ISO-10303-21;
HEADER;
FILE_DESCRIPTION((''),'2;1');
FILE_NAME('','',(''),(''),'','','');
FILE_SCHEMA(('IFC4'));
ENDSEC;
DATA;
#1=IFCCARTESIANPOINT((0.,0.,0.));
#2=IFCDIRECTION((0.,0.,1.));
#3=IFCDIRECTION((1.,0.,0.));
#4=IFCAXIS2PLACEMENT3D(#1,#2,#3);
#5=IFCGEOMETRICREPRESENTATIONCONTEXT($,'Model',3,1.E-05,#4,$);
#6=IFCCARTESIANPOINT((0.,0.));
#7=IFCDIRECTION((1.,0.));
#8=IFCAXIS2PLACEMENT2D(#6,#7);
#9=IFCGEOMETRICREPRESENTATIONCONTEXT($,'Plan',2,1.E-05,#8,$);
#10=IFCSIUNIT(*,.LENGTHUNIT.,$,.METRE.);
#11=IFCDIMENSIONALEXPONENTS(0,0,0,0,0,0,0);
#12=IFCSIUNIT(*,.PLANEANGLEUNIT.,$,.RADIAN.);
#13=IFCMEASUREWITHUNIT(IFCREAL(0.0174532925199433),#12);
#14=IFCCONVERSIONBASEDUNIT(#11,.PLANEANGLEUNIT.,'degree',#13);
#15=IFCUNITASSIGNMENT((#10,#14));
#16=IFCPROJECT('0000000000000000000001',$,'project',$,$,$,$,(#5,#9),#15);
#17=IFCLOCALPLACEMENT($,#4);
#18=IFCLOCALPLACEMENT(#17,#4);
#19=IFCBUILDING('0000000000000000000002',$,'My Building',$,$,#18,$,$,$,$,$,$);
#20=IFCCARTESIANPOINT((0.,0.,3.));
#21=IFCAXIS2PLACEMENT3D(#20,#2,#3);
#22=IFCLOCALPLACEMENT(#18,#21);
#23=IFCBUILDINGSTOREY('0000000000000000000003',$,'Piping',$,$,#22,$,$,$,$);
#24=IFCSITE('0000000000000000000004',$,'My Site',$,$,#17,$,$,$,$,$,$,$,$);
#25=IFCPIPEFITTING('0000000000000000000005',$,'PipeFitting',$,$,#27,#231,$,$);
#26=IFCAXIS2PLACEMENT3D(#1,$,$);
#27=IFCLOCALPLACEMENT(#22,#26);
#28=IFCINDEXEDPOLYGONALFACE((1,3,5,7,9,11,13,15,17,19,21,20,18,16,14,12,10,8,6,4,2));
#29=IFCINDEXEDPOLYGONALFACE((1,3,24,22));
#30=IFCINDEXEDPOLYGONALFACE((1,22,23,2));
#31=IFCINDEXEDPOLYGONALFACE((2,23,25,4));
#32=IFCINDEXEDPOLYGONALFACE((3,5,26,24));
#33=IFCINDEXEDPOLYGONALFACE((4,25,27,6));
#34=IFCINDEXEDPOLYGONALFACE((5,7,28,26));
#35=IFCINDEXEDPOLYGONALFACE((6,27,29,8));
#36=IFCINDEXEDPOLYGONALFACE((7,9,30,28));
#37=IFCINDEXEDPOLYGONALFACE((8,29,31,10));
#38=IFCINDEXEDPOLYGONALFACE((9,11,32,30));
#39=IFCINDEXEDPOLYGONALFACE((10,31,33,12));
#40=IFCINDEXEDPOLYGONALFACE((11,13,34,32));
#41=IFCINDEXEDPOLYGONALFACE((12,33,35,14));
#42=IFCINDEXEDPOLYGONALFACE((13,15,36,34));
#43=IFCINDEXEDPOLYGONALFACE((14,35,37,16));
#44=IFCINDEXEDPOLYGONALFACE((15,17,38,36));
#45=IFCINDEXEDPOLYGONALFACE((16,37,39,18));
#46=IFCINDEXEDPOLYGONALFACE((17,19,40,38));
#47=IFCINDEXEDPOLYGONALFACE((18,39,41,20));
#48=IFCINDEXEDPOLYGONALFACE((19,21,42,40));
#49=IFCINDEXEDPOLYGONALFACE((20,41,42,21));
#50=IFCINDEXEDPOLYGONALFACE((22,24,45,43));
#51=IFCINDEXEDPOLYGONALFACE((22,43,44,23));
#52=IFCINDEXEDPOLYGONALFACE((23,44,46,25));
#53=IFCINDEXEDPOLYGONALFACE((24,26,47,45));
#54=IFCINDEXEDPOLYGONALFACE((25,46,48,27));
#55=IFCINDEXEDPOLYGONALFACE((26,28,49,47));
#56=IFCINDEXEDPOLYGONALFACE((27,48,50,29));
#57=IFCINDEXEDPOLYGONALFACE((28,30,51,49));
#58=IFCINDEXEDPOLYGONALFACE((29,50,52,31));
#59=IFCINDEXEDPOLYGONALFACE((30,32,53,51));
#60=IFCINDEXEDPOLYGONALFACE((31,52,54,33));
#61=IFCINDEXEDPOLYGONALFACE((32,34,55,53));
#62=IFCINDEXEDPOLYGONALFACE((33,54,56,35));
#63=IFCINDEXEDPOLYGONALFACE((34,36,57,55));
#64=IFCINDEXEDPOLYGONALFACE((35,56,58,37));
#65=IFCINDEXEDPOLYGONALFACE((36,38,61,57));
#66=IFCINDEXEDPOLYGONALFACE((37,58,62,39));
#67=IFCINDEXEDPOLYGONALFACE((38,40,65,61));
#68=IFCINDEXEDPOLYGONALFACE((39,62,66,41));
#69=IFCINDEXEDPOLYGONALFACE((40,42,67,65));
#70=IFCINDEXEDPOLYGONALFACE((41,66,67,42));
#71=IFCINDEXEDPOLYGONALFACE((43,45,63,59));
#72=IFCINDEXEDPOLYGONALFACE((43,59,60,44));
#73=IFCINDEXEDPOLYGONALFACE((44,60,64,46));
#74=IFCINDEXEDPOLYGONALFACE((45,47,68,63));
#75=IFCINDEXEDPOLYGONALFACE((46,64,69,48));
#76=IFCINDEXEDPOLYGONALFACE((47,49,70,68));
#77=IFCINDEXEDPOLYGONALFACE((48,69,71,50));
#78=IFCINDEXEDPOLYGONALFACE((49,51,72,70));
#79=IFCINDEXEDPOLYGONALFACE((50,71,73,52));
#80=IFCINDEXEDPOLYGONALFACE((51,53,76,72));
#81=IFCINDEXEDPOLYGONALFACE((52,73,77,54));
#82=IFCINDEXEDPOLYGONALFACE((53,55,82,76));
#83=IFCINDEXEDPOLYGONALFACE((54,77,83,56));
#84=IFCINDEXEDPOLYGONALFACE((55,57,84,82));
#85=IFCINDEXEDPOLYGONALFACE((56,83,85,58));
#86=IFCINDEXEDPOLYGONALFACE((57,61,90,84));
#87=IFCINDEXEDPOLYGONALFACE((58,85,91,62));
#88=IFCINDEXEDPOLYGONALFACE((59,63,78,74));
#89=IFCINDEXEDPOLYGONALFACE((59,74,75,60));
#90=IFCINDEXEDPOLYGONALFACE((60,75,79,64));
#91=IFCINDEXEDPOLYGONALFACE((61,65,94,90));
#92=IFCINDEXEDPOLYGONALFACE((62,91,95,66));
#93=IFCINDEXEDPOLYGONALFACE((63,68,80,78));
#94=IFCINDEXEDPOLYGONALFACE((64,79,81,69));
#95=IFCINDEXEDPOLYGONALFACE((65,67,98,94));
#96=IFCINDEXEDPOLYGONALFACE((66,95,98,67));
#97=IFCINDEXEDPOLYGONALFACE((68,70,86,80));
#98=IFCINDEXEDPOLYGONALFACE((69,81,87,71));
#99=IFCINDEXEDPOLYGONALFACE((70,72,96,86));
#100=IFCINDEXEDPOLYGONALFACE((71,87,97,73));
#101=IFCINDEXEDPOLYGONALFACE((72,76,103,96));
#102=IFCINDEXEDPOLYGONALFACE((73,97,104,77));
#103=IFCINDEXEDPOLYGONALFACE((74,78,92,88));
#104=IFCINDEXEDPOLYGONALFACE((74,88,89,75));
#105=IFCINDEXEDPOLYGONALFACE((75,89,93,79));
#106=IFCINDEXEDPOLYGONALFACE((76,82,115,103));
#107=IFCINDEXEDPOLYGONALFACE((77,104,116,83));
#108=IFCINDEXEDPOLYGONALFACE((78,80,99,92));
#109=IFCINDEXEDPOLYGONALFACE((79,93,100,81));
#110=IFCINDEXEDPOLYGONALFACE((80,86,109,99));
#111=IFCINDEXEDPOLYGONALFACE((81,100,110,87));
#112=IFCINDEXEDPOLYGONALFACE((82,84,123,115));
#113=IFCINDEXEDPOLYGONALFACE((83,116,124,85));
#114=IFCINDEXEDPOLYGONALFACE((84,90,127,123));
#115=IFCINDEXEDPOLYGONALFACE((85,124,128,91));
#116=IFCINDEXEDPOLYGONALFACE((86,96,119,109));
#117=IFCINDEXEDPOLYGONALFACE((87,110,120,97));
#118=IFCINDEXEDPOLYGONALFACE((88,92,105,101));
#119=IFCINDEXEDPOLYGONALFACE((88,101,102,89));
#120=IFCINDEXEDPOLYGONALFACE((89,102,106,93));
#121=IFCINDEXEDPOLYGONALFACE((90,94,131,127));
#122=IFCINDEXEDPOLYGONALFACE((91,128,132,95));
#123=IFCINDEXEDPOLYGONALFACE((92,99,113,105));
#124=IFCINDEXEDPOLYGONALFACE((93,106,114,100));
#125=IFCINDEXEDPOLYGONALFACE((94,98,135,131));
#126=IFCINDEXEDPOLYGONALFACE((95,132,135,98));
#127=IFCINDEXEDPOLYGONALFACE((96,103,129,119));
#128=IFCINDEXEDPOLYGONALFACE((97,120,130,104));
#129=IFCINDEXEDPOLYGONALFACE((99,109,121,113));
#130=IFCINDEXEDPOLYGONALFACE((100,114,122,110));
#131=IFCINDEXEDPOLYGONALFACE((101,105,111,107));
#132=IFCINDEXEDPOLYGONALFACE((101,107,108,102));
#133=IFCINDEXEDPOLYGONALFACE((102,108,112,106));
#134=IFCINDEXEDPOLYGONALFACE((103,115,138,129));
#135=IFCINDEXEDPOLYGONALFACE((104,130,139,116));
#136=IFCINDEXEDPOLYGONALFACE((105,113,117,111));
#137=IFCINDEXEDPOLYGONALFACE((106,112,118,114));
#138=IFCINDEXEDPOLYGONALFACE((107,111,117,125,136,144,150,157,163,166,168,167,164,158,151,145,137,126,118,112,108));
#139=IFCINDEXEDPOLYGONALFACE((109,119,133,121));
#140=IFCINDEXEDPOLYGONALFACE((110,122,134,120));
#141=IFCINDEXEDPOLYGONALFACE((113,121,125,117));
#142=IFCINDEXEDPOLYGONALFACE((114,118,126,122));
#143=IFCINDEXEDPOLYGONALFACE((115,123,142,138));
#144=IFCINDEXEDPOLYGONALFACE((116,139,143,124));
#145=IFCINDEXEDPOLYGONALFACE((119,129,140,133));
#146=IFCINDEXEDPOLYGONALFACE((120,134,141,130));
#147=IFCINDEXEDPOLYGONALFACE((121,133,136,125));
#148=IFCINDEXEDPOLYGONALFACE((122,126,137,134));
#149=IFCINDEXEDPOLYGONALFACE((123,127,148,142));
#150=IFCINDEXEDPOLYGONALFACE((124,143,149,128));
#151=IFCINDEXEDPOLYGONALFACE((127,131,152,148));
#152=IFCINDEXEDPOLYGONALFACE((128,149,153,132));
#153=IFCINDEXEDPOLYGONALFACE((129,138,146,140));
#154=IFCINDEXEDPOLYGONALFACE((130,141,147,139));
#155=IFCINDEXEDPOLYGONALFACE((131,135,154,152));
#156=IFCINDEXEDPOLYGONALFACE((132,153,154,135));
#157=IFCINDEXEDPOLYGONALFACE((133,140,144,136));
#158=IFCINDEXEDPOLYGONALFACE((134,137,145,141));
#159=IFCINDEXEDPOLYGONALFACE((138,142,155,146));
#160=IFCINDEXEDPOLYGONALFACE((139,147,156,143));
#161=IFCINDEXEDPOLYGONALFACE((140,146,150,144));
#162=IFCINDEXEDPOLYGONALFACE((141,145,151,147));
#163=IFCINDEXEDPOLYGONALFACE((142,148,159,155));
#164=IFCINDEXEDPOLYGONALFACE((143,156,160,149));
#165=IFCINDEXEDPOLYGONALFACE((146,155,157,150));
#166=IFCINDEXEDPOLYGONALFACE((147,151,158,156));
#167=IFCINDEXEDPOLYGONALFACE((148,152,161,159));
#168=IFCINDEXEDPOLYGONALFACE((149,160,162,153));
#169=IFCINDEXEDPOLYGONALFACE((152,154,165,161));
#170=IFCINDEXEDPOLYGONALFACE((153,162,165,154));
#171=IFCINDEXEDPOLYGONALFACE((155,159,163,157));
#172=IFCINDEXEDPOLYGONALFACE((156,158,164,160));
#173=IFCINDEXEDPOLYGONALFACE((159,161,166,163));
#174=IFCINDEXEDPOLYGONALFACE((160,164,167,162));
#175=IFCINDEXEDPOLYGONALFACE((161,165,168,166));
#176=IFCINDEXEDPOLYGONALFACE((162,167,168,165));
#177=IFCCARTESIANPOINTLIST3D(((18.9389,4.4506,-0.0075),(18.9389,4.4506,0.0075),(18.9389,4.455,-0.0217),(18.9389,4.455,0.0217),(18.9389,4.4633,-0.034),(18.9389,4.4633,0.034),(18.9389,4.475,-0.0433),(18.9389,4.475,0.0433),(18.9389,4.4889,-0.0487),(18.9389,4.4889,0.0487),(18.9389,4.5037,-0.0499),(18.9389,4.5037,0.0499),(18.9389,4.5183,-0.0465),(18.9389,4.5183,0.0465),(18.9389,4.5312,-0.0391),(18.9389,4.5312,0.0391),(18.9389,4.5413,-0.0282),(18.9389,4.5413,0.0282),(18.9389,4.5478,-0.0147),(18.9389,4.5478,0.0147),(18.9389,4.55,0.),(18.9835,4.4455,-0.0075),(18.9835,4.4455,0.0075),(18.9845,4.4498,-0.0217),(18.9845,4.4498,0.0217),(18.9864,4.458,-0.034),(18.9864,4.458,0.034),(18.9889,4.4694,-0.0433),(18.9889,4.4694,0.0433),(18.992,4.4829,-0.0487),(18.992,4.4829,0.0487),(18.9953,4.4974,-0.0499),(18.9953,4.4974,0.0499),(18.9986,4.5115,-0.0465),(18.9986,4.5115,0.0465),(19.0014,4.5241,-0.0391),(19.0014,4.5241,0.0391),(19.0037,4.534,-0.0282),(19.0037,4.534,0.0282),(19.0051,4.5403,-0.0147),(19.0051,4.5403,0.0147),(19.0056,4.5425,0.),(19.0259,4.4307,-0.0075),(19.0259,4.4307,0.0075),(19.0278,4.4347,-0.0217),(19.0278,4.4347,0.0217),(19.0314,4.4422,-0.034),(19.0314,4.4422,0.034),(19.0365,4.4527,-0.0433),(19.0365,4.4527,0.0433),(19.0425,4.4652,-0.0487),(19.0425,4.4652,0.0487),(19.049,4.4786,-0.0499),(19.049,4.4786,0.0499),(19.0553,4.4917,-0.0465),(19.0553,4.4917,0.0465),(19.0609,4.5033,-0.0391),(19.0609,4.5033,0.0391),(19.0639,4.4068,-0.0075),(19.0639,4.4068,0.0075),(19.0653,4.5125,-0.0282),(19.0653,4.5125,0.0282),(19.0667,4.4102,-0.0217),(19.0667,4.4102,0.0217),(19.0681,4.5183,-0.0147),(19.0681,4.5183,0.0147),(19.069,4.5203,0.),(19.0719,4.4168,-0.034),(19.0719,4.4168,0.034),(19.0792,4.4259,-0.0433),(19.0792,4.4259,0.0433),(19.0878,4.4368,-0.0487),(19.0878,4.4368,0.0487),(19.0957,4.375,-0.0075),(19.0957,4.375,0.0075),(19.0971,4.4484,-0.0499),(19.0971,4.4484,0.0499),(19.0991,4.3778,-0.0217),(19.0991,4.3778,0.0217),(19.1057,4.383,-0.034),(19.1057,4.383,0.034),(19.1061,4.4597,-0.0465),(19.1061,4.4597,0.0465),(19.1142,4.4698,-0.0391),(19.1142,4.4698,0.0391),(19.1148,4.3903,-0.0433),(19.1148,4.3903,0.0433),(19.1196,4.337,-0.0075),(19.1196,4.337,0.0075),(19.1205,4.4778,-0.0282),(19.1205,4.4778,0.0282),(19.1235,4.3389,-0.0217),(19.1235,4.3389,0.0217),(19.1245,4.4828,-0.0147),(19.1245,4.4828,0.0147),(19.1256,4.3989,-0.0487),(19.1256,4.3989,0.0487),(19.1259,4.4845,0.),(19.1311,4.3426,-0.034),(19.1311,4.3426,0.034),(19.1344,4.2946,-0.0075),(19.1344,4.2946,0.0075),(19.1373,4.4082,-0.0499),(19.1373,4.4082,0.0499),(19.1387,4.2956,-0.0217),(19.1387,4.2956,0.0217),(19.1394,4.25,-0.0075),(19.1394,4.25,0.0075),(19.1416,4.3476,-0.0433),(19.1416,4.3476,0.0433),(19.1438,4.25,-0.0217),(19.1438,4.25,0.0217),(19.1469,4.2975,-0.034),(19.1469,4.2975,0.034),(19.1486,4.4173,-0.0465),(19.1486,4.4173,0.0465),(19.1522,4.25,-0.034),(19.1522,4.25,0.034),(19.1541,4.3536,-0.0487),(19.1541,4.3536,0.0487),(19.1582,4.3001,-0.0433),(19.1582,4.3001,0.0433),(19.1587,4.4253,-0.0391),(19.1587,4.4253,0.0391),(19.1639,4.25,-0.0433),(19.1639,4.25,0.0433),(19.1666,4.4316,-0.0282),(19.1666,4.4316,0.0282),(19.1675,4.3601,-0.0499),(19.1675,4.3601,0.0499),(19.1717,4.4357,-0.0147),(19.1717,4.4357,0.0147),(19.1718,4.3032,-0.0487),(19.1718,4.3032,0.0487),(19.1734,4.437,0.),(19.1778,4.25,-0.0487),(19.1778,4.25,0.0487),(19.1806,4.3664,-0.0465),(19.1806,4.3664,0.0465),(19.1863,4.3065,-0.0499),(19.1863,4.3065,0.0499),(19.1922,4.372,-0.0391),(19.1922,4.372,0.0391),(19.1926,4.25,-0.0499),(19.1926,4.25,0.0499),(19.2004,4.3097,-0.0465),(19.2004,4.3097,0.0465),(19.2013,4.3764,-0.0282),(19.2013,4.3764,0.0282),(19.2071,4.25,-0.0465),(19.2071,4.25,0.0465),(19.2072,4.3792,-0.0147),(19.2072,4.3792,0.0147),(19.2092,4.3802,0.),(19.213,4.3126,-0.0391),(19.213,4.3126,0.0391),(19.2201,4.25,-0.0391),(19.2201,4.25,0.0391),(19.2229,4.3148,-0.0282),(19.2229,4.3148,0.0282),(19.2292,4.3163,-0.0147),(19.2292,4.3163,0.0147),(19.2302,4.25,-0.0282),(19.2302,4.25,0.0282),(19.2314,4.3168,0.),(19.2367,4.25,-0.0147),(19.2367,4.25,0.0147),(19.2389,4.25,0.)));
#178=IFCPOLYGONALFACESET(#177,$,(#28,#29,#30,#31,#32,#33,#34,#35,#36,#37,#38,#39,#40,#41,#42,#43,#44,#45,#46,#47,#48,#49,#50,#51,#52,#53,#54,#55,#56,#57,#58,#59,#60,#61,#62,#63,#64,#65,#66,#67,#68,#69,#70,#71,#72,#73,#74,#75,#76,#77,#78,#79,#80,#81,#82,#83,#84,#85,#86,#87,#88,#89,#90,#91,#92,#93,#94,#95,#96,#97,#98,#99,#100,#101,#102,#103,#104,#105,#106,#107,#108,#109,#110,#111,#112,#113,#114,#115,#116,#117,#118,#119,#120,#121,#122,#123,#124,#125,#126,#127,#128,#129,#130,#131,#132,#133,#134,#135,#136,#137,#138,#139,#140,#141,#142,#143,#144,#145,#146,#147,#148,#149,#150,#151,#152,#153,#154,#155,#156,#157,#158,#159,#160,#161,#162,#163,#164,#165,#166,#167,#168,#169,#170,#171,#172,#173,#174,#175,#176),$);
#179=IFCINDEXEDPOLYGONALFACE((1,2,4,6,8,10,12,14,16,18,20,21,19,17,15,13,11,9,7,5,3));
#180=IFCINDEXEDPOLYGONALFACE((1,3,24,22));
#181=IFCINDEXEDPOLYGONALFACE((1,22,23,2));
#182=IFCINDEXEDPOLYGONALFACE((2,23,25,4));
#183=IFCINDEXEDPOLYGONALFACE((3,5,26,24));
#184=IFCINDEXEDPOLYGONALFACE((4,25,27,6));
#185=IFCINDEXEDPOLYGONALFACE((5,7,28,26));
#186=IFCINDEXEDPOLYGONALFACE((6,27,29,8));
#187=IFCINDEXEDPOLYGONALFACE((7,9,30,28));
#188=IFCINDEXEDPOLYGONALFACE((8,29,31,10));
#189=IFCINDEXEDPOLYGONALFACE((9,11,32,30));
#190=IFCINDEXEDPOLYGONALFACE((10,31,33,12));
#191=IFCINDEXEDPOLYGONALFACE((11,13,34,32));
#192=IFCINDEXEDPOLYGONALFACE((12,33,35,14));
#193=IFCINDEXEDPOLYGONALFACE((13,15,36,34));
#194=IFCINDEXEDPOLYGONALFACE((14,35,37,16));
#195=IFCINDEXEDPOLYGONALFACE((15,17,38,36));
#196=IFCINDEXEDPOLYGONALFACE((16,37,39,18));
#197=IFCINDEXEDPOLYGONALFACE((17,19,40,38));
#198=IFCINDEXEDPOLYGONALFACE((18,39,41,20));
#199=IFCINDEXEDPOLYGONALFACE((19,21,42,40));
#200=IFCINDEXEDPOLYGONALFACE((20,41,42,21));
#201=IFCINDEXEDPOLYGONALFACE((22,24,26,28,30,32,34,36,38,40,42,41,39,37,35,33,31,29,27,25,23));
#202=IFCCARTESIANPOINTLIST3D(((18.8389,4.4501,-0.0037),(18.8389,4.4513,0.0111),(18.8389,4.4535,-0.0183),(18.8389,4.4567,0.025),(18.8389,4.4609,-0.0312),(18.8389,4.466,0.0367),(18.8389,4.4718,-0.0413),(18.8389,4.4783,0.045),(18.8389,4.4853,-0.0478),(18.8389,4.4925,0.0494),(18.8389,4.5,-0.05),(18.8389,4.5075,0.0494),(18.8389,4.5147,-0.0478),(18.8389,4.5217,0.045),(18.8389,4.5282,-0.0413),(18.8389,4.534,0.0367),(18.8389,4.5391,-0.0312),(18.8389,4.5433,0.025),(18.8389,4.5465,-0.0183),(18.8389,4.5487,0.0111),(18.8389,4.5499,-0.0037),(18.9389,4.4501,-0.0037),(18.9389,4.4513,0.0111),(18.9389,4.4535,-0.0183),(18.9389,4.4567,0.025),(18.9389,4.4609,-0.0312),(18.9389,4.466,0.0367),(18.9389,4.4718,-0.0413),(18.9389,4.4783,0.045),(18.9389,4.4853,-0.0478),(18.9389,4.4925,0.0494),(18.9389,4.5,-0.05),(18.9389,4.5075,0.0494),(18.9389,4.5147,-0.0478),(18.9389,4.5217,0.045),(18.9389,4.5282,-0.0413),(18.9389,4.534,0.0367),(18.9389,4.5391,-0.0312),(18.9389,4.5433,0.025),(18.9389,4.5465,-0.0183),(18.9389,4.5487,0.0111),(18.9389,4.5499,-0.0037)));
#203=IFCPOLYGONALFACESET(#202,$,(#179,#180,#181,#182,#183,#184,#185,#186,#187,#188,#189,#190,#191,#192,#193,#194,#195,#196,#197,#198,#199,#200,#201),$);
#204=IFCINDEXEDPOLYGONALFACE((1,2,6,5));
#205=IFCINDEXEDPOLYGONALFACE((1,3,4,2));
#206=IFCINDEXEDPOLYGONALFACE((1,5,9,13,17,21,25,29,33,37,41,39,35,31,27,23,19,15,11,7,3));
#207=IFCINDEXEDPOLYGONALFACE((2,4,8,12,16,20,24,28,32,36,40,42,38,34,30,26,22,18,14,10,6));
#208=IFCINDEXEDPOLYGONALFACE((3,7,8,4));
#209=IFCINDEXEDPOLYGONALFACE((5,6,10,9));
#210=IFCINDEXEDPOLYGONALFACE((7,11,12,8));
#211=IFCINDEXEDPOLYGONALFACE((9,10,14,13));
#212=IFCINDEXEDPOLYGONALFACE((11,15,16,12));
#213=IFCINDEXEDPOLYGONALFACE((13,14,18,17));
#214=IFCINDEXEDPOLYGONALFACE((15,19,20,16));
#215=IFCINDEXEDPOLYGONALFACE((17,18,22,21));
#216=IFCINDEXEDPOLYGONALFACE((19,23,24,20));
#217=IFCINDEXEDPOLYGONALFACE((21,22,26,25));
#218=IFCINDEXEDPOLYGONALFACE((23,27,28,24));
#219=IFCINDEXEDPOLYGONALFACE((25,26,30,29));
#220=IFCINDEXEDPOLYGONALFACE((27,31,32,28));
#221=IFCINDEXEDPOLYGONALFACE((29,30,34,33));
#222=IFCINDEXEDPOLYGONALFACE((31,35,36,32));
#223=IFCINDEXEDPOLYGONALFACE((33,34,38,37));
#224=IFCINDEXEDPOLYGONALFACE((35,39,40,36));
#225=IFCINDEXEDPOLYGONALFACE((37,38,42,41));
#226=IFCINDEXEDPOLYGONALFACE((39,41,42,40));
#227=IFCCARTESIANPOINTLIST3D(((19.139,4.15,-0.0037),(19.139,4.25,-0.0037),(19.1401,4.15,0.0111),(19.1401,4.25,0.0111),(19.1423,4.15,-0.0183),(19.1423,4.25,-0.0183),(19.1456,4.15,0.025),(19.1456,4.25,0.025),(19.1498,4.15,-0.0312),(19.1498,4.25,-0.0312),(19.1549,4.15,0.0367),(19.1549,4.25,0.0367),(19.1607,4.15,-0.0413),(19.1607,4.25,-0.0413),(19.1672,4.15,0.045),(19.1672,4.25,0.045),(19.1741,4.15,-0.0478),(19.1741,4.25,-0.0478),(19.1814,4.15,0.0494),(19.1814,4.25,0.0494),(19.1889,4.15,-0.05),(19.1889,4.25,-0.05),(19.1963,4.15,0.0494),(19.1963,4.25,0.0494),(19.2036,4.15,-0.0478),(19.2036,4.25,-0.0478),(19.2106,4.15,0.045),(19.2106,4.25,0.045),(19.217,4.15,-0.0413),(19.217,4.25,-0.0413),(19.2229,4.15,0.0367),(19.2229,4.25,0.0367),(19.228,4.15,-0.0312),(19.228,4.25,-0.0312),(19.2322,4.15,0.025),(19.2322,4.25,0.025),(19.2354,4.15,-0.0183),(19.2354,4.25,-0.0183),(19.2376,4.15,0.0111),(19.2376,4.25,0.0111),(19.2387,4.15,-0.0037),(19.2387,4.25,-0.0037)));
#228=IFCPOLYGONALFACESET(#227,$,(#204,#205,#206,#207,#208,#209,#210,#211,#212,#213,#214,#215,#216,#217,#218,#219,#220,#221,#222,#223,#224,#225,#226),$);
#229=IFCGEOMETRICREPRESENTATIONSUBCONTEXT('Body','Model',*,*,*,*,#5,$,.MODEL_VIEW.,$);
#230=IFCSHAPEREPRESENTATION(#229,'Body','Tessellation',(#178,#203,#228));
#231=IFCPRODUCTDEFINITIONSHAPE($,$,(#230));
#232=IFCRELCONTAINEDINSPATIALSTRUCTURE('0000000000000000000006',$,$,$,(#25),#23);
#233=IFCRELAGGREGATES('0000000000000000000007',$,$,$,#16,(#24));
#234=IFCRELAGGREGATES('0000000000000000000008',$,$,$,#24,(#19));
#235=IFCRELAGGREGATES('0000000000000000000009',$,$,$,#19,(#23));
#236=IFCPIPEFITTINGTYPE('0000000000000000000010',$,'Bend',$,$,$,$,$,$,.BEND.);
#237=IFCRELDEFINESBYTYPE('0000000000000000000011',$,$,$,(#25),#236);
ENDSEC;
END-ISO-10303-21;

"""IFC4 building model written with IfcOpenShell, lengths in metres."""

from ifc_helpers import new_model, entity, si_unit, converted_unit, frame, origin_with_axes, origin_2d_with_axis, place, context, subcontext, project, spatial, circle, extrude, source, transform, mapped, type_object, type_shapes, element, save


model = new_model("IFC4")

# Units and contexts
model_context = context("Model", 3, precision=1e-05, world=origin_with_axes())
plan_context = context("Plan", 2, precision=1e-05, world=origin_2d_with_axis())
body_context = subcontext(model_context, "Body", "Model", "MODEL_VIEW")
ifc_project = project(units=[si_unit("LENGTHUNIT", "METRE"), converted_unit("PLANEANGLEUNIT", "degree", entity("IfcReal", 0.0174532925199433), si_unit("PLANEANGLEUNIT", "RADIAN"), dimensions=[0, 0, 0, 0, 0, 0, 0])], contexts=[model_context, plan_context])

# Site, building, storey
site_placement = place(None, origin_with_axes())
site = spatial("IfcSite", under=ifc_project, at=site_placement, Name="My Site")
building_placement = place(site_placement, origin_with_axes())
building = spatial("IfcBuilding", under=site, at=building_placement, Name="My Building")
storey_placement = place(building_placement, frame((0.0, 0.0, 3.0), z_axis=(0.0, 0.0, 1.0), x_axis=(1.0, 0.0, 0.0)))
storey = spatial("IfcBuildingStorey", under=building, at=storey_placement, Name="Piping")

# Shared definitions
pipe_fitting_type = type_object("IfcPipeFittingType", Name="Bend", PredefinedType="BEND")
shared_shape = source(origin_with_axes(), body_context, "Body", "SolidModel", [
    entity("IfcSweptDiskSolid", entity("IfcIndexedPolyCurve", entity("IfcCartesianPointList3D", [[0.0, 0.0, -0.1], [0.0, 0.0732, -0.2768], [0.0, 0.25, -0.35]]), [entity("IfcArcIndex", [1, 2, 3])]), 0.05),
    extrude(circle(Radius=0.05), origin_with_axes(), (0.0, 0.0, -1.0), 0.1),
    extrude(circle(Radius=0.05), frame((0.0, 0.25, -0.35), z_axis=(0.0, 1.0, 0.0), x_axis=(1.0, 0.0, 0.0)), (0.0, 0.0, 1.0), 0.1),
])
type_shapes(pipe_fitting_type, [shared_shape])

# Pipe fitting
for number, where, z_axis, x_axis, name in (
    (1, (18.8389, 4.5, 0.0), (-1.0, 0.0, 0.0), (0.0, 0.0, -1.0), "PipeFitting"),
):
    element("IfcPipeFitting", number, at=place(storey_placement, frame(where, z_axis=z_axis, x_axis=x_axis)), inside=storey, type_object=pipe_fitting_type, Name=name, context=body_context, shape_type="MappedRepresentation", body=[
        mapped(shared_shape, transform((0.0, 0.0, 0.0), x_axis=(1.0, 0.0, 0.0), y_axis=(0.0, 1.0, 0.0), z_axis=(0.0, 0.0, 1.0), scale=1.0)),
    ])

save(model, "model.ifc")
